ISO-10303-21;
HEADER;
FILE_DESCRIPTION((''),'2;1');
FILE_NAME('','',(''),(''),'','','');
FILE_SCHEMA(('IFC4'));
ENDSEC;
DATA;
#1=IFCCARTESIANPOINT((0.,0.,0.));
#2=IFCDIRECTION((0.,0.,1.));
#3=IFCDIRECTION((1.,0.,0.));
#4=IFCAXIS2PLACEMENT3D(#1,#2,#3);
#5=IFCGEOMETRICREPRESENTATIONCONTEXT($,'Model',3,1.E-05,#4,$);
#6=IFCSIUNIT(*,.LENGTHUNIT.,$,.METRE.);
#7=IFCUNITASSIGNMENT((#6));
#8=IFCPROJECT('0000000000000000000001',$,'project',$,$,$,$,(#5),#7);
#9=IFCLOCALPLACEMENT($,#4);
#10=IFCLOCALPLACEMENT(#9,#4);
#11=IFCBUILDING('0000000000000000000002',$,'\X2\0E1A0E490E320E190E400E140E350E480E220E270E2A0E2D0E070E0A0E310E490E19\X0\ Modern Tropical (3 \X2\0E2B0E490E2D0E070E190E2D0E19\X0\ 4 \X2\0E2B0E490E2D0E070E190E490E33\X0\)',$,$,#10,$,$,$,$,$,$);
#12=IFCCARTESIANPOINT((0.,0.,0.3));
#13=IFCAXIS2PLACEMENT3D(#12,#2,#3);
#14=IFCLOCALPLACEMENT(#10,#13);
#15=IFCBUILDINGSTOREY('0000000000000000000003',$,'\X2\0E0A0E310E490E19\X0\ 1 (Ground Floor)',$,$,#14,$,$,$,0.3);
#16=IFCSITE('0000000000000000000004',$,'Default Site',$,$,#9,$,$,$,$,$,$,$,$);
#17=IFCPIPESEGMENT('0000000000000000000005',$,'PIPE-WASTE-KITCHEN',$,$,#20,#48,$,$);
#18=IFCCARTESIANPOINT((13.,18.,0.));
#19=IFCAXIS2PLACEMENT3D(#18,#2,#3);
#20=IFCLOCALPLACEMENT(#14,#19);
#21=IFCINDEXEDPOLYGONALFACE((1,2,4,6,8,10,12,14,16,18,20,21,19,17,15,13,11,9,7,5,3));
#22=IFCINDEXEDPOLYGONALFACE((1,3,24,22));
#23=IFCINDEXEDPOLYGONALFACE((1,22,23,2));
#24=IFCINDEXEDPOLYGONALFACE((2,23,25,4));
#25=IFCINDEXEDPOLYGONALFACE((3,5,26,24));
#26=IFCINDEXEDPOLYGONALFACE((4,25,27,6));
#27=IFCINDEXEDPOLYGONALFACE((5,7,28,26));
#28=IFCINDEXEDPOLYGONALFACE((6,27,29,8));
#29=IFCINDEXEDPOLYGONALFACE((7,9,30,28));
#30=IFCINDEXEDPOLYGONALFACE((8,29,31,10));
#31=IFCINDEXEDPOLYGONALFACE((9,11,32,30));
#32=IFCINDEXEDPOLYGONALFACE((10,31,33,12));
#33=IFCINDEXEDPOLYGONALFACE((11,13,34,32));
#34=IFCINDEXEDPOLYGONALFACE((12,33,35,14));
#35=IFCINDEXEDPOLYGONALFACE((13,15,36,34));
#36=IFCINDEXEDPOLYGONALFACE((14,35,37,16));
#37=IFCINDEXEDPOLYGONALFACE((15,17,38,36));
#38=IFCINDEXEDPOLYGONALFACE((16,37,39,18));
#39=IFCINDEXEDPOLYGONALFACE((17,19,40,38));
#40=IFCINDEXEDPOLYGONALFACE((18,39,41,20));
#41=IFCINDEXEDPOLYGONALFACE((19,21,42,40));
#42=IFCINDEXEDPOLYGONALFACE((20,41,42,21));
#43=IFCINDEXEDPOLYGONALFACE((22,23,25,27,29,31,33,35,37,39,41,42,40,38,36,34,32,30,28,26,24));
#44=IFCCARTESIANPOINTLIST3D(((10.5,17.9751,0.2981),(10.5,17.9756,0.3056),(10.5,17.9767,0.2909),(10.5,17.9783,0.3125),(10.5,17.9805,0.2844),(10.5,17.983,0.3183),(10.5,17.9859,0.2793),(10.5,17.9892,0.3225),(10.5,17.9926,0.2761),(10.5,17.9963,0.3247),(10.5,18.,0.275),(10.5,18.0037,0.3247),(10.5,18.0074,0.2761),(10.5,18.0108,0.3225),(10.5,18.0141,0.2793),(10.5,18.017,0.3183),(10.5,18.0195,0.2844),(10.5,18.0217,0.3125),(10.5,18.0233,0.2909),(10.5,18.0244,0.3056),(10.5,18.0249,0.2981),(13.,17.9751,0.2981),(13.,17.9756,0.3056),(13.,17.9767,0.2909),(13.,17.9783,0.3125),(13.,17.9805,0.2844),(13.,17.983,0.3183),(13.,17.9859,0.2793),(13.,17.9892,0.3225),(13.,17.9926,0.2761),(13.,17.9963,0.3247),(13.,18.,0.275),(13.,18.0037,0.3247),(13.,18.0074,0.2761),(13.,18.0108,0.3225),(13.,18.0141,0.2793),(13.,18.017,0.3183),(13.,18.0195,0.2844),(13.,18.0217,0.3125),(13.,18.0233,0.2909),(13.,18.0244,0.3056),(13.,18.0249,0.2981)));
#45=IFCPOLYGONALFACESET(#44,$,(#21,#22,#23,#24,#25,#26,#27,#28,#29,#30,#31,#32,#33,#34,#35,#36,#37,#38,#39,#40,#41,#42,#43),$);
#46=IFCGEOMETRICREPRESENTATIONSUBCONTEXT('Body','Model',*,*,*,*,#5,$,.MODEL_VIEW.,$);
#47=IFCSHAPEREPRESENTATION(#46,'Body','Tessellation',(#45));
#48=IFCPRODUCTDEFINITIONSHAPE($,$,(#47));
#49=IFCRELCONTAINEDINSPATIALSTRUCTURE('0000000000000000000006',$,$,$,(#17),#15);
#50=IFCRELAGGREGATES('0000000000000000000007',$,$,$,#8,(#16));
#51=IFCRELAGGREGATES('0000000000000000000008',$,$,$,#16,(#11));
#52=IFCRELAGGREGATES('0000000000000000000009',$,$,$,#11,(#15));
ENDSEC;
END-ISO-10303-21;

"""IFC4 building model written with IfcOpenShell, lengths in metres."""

from ifc_helpers import new_model, entity, si_unit, frame, origin_with_axes, place, context, subcontext, project, spatial, element, save


model = new_model("IFC4")

# Units and contexts
model_context = context("Model", 3, precision=1e-05, world=origin_with_axes())
body_context = subcontext(model_context, "Body", "Model", "MODEL_VIEW")
ifc_project = project(units=[si_unit("LENGTHUNIT", "METRE")], contexts=[model_context])

# Site, building, storey
site_placement = place(None, origin_with_axes())
site = spatial("IfcSite", under=ifc_project, at=site_placement, Name="Default Site")
building_placement = place(site_placement, origin_with_axes())
building = spatial("IfcBuilding", under=site, at=building_placement, Name="บ้านเดี่ยวสองชั้น Modern Tropical (3 ห้องนอน 4 ห้องน้ำ)")
storey_placement = place(building_placement, frame((0.0, 0.0, 0.3), z_axis=(0.0, 0.0, 1.0), x_axis=(1.0, 0.0, 0.0)))
storey = spatial("IfcBuildingStorey", under=building, at=storey_placement, Name="ชั้น 1 (Ground Floor)", Elevation=0.3)

# Pipe segment
pipe_segment_placement = place(storey_placement, frame((13.0, 18.0, 0.0), z_axis=(0.0, 0.0, 1.0), x_axis=(1.0, 0.0, 0.0)))
element("IfcPipeSegment", 1, at=pipe_segment_placement, inside=storey, Name="PIPE-WASTE-KITCHEN", context=body_context, shape_type="SweptSolid", body=[
    entity("IfcSweptDiskSolid", entity("IfcPolyline", [entity("IfcCartesianPoint", [13.0, 18.0, 0.3]), entity("IfcCartesianPoint", [10.5, 18.0, 0.3])]), 0.025),
])

save(model, "model.ifc")
